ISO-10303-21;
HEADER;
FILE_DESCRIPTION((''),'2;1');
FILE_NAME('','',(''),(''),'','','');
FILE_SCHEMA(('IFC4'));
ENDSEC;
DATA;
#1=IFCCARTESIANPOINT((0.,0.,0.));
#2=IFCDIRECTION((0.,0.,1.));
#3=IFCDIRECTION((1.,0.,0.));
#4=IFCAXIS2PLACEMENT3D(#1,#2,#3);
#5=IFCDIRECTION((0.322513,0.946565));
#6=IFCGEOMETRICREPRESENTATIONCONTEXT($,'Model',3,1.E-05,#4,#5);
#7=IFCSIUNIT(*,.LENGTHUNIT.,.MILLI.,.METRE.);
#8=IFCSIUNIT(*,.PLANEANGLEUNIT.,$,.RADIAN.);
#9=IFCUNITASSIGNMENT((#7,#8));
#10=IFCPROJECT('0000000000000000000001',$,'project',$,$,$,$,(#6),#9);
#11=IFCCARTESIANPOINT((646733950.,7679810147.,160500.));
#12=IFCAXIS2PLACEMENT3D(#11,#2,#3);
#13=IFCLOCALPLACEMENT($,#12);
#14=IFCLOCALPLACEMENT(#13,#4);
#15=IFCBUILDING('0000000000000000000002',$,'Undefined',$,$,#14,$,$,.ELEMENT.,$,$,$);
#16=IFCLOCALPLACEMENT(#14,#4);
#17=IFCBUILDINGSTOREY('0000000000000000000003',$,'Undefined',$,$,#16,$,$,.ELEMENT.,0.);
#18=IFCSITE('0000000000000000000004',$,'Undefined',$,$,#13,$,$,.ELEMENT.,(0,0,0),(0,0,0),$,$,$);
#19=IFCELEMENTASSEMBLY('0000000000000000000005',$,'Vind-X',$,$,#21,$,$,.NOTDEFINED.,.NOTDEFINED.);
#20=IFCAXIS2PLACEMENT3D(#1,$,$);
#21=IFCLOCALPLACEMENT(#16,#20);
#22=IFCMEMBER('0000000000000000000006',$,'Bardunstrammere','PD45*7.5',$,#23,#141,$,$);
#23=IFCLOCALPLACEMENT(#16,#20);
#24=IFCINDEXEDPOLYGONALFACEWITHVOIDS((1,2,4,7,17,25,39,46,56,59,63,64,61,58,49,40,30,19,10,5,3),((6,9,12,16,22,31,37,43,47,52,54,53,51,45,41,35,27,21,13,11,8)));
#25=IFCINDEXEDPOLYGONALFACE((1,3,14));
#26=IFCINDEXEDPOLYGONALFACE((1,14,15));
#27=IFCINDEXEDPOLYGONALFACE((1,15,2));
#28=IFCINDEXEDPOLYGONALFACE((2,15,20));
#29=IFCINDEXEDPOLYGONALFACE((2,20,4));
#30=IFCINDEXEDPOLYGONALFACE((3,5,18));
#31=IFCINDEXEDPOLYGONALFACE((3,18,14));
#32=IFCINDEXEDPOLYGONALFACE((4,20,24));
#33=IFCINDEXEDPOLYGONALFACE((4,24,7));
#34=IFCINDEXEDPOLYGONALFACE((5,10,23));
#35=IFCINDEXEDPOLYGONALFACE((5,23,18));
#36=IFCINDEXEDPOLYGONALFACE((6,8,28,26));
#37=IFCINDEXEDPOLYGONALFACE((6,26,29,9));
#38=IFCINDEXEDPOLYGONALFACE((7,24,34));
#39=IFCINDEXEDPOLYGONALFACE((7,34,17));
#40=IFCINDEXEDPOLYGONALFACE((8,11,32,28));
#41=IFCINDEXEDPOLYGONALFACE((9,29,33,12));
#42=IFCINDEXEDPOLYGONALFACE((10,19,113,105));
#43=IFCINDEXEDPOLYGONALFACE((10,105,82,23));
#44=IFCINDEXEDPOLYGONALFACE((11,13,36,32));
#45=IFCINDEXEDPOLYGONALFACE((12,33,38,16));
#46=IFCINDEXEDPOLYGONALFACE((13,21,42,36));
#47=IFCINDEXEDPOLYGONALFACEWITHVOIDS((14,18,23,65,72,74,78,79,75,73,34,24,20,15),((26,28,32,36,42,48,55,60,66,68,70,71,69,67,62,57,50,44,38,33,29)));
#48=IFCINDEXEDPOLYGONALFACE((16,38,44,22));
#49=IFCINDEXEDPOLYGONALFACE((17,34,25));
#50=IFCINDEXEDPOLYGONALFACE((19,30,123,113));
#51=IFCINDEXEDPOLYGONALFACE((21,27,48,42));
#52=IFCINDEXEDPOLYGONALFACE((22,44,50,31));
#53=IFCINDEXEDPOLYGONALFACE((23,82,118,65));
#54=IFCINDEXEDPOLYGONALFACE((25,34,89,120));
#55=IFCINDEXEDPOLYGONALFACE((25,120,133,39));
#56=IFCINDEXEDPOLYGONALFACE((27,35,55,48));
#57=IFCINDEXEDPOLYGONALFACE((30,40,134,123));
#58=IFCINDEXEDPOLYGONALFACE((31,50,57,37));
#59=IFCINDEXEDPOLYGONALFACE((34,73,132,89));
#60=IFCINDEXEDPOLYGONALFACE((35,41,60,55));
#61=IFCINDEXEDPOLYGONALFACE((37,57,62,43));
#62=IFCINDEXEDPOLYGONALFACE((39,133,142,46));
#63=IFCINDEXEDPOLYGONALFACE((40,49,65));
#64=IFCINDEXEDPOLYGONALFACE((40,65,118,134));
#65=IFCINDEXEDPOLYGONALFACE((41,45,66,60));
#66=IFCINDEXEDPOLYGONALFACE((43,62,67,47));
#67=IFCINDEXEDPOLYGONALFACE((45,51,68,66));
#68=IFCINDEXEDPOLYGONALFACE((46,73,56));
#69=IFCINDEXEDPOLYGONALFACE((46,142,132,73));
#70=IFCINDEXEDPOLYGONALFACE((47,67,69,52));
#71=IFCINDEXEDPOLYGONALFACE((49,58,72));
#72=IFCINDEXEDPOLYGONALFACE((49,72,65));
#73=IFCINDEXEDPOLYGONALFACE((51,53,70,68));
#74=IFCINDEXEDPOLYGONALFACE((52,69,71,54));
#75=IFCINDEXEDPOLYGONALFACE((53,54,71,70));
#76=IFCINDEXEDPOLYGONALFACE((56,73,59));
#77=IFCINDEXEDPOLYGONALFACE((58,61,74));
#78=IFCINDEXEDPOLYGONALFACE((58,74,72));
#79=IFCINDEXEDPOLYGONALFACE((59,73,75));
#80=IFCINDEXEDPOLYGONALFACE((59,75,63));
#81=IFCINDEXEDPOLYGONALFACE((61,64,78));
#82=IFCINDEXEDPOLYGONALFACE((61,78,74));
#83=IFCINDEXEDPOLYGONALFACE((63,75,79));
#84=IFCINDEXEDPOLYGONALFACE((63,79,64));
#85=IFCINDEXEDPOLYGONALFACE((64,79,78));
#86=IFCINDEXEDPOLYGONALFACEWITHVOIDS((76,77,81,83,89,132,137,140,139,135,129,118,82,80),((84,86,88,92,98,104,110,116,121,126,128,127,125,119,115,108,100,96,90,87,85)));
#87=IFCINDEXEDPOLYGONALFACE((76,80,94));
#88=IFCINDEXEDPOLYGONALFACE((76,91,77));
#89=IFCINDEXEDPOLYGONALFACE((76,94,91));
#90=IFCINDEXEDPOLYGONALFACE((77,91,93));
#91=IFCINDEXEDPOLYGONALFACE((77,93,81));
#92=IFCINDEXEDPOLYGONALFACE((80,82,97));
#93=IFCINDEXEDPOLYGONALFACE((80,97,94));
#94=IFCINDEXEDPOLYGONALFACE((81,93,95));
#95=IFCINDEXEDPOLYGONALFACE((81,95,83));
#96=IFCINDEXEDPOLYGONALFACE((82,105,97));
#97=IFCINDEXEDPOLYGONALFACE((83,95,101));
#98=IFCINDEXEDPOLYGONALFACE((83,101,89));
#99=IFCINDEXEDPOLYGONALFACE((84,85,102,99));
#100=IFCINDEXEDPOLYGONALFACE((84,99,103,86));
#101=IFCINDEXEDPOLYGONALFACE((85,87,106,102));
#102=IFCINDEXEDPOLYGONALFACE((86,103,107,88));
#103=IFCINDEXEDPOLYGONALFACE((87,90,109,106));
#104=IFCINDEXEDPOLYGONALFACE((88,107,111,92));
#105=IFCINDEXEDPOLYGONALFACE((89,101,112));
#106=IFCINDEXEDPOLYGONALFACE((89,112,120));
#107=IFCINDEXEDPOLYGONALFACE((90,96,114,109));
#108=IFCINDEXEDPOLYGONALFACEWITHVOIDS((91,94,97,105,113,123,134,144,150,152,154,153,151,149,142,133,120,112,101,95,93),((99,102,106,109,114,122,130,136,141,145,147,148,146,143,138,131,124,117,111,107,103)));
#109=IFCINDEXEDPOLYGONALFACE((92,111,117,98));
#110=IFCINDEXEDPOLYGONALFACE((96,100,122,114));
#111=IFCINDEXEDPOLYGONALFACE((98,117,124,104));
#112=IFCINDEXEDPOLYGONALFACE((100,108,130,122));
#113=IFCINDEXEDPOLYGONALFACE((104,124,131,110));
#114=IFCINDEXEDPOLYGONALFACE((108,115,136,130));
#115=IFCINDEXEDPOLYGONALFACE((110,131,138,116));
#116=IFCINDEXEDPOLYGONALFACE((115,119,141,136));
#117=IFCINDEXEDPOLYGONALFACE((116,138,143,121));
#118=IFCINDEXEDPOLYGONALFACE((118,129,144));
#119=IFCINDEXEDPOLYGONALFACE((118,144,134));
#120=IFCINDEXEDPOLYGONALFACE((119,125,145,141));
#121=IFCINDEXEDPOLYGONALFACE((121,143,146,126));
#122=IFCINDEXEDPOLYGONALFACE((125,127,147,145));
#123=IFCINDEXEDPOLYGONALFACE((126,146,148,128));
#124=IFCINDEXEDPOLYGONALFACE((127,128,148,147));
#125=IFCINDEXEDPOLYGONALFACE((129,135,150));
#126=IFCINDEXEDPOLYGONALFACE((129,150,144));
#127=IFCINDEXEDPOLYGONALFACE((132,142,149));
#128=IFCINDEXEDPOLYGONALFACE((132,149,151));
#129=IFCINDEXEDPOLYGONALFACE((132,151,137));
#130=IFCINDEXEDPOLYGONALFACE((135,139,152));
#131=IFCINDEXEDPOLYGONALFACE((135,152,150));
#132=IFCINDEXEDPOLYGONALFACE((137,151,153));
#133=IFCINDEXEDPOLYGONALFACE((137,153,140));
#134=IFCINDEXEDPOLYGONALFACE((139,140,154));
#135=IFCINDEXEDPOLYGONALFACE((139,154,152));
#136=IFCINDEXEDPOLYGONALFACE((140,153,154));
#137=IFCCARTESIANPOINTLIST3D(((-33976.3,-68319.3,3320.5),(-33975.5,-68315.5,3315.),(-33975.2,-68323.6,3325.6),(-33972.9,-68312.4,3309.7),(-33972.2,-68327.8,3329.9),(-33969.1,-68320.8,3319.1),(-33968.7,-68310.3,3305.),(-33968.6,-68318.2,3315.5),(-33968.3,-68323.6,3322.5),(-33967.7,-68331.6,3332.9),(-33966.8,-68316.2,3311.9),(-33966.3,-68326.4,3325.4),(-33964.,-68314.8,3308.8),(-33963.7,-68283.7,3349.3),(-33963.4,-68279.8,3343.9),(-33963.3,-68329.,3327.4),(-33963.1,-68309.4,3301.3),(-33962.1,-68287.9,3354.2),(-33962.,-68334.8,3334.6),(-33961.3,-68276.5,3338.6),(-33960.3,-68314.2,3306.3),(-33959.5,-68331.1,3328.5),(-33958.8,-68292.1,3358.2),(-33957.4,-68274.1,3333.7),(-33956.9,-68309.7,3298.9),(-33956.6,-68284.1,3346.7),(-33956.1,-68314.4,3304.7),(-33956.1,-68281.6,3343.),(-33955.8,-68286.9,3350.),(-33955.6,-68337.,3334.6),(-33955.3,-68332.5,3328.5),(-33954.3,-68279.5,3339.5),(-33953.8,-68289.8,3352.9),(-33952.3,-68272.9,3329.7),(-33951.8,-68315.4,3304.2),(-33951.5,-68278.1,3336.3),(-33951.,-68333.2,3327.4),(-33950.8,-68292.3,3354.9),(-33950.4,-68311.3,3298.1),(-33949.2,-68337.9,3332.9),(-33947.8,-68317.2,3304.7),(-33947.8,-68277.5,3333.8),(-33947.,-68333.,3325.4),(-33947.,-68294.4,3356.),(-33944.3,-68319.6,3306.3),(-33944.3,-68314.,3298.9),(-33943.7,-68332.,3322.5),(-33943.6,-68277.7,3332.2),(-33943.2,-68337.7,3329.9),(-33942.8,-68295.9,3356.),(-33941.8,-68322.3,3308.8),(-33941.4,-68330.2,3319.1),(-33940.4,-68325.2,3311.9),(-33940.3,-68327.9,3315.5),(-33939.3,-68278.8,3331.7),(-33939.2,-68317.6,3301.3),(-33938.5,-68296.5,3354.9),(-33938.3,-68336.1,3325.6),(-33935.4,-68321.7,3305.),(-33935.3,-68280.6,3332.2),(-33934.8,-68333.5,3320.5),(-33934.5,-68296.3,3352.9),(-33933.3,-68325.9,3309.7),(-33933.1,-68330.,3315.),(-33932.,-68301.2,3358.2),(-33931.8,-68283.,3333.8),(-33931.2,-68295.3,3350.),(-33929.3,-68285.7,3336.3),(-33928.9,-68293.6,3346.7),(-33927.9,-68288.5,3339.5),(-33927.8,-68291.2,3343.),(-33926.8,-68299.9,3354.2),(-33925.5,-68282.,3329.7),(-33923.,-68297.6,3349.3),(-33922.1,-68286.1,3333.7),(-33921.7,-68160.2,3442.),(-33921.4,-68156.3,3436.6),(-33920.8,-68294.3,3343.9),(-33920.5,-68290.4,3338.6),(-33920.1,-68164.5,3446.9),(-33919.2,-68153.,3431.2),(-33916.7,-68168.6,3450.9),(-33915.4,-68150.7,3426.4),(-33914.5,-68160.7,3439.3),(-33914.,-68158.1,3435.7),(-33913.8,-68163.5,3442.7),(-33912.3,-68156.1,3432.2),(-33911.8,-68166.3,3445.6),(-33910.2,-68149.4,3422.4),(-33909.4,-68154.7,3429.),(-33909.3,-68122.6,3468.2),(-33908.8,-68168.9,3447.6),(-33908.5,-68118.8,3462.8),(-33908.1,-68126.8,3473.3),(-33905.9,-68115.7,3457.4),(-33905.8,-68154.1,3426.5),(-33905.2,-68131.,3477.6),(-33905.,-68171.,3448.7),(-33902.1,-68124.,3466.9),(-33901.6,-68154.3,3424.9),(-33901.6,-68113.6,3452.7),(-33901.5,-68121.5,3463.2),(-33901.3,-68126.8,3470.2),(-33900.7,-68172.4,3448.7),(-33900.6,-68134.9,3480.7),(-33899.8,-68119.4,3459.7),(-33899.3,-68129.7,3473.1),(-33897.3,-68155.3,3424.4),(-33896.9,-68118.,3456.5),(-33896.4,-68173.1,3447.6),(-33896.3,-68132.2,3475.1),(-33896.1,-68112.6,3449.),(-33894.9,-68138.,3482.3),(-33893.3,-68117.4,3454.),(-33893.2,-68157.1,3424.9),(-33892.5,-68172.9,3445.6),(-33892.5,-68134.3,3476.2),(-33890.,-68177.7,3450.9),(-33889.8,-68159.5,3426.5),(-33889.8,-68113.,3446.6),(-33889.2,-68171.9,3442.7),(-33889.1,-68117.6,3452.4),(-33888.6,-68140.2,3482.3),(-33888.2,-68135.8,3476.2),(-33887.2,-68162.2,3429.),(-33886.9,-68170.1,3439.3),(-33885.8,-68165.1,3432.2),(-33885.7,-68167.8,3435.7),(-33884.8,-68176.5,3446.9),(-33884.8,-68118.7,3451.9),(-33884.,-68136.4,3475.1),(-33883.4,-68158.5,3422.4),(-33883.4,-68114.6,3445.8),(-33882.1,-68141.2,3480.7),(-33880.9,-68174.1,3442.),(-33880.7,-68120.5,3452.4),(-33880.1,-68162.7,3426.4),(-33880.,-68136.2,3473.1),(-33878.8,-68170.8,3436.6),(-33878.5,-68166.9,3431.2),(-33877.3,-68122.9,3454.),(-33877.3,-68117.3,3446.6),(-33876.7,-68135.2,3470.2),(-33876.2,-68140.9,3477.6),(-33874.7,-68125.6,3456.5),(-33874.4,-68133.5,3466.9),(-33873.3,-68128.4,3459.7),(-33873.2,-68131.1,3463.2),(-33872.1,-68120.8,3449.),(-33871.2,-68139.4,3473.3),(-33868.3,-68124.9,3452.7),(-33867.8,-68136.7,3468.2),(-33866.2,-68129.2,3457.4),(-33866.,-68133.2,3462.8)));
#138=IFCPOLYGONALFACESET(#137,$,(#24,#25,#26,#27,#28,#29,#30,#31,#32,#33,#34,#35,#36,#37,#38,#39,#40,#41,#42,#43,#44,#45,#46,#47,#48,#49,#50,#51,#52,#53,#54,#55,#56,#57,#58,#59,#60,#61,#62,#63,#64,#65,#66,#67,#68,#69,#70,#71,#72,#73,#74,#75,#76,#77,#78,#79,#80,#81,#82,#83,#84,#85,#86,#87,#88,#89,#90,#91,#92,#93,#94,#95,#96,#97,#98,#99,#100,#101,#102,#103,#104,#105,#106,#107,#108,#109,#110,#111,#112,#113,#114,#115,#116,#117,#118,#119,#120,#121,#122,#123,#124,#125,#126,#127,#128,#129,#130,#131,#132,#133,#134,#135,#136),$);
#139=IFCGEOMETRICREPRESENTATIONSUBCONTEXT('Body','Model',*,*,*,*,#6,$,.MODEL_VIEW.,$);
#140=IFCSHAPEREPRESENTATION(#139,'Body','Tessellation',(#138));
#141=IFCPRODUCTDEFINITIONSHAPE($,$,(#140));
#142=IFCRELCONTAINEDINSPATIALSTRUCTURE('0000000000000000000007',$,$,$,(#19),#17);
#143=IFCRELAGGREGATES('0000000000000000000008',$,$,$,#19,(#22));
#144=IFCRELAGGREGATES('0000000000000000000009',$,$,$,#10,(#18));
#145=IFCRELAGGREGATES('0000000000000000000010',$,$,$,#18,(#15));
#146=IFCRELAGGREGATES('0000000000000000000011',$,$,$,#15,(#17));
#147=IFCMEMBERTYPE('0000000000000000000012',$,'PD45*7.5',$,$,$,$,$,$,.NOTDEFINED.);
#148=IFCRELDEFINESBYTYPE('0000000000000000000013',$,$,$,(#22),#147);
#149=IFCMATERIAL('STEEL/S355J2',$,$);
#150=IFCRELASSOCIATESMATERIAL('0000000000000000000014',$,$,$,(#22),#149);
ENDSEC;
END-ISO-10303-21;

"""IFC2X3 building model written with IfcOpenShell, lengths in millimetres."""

from ifc_helpers import new_model, si_unit, direction, frame, origin_with_axes, origin_2d_with_axis, place, context, subcontext, project, spatial, rectangle, hollow_circle, extrude, boolean, material, type_object, element, aggregate, save


model = new_model("IFC2X3")

# Units and contexts
model_context = context("Model", 3, precision=1e-05, world=origin_with_axes(), true_north=direction((0.322513, 0.946565)))
body_context = subcontext(model_context, "Body", "Model", "MODEL_VIEW")
ifc_project = project(units=[si_unit("LENGTHUNIT", "METRE", prefix="MILLI"), si_unit("PLANEANGLEUNIT", "RADIAN")], contexts=[model_context])

# Site, building, storey
site_placement = place(None, frame((646733950.0, 7679810147.0, 160500.0), z_axis=(0.0, 0.0, 1.0), x_axis=(1.0, 0.0, 0.0)))
site = spatial("IfcSite", under=ifc_project, at=site_placement, Name="Undefined", CompositionType="ELEMENT", RefLatitude=(0, 0, 0), RefLongitude=(0, 0, 0))
building_placement = place(site_placement, origin_with_axes())
building = spatial("IfcBuilding", under=site, at=building_placement, Name="Undefined", CompositionType="ELEMENT")
storey_placement = place(building_placement, origin_with_axes())
storey = spatial("IfcBuildingStorey", under=building, at=storey_placement, Name="Undefined", CompositionType="ELEMENT", Elevation=0.0)

# Element assembly
assembly_1_placement = place(storey_placement, origin_with_axes())
assembly_1 = element("IfcElementAssembly", 1, at=assembly_1_placement, inside=storey, Name="Vind-X", AssemblyPlace="NOTDEFINED", PredefinedType="NOTDEFINED")
ifc_material_1 = material(Name="STEEL/S355J2")

# Member
member_type_1 = type_object("IfcMemberType", Name="PD45*7.5", PredefinedType="NOTDEFINED")
member_1_placement = place(assembly_1_placement, frame((-33887.6, -68126.9, 3464.1), z_axis=(-0.946565, 0.322513, 0.0), x_axis=(-0.262889, -0.77157, -0.579284)))
member_1 = element("IfcMember", 2, at=member_1_placement, type_object=member_type_1, material=ifc_material_1, Name="Bardunstrammere", Description="PD45*7.5", context=body_context, shape_type="CSG", body=[
    boolean("DIFFERENCE", extrude(hollow_circle(Radius=22.5, WallThickness=7.5, at=origin_2d_with_axis()), frame((255.0, 0.0, 0.0), z_axis=(-1.0, 0.0, 0.0), x_axis=(0.0, -1.0, 0.0)), (0.0, 0.0, 1.0), 255.0), extrude(rectangle(XDim=35.0, YDim=90.0, at=origin_2d_with_axis()), frame((207.5, 0.0, 0.0), z_axis=(-1.0, 0.0, 0.0), x_axis=(0.0, -1.0, 0.0)), (0.0, 0.0, 1.0), 160.0)),
])

aggregate(assembly_1, [member_1])

save(model, "model.ifc")
